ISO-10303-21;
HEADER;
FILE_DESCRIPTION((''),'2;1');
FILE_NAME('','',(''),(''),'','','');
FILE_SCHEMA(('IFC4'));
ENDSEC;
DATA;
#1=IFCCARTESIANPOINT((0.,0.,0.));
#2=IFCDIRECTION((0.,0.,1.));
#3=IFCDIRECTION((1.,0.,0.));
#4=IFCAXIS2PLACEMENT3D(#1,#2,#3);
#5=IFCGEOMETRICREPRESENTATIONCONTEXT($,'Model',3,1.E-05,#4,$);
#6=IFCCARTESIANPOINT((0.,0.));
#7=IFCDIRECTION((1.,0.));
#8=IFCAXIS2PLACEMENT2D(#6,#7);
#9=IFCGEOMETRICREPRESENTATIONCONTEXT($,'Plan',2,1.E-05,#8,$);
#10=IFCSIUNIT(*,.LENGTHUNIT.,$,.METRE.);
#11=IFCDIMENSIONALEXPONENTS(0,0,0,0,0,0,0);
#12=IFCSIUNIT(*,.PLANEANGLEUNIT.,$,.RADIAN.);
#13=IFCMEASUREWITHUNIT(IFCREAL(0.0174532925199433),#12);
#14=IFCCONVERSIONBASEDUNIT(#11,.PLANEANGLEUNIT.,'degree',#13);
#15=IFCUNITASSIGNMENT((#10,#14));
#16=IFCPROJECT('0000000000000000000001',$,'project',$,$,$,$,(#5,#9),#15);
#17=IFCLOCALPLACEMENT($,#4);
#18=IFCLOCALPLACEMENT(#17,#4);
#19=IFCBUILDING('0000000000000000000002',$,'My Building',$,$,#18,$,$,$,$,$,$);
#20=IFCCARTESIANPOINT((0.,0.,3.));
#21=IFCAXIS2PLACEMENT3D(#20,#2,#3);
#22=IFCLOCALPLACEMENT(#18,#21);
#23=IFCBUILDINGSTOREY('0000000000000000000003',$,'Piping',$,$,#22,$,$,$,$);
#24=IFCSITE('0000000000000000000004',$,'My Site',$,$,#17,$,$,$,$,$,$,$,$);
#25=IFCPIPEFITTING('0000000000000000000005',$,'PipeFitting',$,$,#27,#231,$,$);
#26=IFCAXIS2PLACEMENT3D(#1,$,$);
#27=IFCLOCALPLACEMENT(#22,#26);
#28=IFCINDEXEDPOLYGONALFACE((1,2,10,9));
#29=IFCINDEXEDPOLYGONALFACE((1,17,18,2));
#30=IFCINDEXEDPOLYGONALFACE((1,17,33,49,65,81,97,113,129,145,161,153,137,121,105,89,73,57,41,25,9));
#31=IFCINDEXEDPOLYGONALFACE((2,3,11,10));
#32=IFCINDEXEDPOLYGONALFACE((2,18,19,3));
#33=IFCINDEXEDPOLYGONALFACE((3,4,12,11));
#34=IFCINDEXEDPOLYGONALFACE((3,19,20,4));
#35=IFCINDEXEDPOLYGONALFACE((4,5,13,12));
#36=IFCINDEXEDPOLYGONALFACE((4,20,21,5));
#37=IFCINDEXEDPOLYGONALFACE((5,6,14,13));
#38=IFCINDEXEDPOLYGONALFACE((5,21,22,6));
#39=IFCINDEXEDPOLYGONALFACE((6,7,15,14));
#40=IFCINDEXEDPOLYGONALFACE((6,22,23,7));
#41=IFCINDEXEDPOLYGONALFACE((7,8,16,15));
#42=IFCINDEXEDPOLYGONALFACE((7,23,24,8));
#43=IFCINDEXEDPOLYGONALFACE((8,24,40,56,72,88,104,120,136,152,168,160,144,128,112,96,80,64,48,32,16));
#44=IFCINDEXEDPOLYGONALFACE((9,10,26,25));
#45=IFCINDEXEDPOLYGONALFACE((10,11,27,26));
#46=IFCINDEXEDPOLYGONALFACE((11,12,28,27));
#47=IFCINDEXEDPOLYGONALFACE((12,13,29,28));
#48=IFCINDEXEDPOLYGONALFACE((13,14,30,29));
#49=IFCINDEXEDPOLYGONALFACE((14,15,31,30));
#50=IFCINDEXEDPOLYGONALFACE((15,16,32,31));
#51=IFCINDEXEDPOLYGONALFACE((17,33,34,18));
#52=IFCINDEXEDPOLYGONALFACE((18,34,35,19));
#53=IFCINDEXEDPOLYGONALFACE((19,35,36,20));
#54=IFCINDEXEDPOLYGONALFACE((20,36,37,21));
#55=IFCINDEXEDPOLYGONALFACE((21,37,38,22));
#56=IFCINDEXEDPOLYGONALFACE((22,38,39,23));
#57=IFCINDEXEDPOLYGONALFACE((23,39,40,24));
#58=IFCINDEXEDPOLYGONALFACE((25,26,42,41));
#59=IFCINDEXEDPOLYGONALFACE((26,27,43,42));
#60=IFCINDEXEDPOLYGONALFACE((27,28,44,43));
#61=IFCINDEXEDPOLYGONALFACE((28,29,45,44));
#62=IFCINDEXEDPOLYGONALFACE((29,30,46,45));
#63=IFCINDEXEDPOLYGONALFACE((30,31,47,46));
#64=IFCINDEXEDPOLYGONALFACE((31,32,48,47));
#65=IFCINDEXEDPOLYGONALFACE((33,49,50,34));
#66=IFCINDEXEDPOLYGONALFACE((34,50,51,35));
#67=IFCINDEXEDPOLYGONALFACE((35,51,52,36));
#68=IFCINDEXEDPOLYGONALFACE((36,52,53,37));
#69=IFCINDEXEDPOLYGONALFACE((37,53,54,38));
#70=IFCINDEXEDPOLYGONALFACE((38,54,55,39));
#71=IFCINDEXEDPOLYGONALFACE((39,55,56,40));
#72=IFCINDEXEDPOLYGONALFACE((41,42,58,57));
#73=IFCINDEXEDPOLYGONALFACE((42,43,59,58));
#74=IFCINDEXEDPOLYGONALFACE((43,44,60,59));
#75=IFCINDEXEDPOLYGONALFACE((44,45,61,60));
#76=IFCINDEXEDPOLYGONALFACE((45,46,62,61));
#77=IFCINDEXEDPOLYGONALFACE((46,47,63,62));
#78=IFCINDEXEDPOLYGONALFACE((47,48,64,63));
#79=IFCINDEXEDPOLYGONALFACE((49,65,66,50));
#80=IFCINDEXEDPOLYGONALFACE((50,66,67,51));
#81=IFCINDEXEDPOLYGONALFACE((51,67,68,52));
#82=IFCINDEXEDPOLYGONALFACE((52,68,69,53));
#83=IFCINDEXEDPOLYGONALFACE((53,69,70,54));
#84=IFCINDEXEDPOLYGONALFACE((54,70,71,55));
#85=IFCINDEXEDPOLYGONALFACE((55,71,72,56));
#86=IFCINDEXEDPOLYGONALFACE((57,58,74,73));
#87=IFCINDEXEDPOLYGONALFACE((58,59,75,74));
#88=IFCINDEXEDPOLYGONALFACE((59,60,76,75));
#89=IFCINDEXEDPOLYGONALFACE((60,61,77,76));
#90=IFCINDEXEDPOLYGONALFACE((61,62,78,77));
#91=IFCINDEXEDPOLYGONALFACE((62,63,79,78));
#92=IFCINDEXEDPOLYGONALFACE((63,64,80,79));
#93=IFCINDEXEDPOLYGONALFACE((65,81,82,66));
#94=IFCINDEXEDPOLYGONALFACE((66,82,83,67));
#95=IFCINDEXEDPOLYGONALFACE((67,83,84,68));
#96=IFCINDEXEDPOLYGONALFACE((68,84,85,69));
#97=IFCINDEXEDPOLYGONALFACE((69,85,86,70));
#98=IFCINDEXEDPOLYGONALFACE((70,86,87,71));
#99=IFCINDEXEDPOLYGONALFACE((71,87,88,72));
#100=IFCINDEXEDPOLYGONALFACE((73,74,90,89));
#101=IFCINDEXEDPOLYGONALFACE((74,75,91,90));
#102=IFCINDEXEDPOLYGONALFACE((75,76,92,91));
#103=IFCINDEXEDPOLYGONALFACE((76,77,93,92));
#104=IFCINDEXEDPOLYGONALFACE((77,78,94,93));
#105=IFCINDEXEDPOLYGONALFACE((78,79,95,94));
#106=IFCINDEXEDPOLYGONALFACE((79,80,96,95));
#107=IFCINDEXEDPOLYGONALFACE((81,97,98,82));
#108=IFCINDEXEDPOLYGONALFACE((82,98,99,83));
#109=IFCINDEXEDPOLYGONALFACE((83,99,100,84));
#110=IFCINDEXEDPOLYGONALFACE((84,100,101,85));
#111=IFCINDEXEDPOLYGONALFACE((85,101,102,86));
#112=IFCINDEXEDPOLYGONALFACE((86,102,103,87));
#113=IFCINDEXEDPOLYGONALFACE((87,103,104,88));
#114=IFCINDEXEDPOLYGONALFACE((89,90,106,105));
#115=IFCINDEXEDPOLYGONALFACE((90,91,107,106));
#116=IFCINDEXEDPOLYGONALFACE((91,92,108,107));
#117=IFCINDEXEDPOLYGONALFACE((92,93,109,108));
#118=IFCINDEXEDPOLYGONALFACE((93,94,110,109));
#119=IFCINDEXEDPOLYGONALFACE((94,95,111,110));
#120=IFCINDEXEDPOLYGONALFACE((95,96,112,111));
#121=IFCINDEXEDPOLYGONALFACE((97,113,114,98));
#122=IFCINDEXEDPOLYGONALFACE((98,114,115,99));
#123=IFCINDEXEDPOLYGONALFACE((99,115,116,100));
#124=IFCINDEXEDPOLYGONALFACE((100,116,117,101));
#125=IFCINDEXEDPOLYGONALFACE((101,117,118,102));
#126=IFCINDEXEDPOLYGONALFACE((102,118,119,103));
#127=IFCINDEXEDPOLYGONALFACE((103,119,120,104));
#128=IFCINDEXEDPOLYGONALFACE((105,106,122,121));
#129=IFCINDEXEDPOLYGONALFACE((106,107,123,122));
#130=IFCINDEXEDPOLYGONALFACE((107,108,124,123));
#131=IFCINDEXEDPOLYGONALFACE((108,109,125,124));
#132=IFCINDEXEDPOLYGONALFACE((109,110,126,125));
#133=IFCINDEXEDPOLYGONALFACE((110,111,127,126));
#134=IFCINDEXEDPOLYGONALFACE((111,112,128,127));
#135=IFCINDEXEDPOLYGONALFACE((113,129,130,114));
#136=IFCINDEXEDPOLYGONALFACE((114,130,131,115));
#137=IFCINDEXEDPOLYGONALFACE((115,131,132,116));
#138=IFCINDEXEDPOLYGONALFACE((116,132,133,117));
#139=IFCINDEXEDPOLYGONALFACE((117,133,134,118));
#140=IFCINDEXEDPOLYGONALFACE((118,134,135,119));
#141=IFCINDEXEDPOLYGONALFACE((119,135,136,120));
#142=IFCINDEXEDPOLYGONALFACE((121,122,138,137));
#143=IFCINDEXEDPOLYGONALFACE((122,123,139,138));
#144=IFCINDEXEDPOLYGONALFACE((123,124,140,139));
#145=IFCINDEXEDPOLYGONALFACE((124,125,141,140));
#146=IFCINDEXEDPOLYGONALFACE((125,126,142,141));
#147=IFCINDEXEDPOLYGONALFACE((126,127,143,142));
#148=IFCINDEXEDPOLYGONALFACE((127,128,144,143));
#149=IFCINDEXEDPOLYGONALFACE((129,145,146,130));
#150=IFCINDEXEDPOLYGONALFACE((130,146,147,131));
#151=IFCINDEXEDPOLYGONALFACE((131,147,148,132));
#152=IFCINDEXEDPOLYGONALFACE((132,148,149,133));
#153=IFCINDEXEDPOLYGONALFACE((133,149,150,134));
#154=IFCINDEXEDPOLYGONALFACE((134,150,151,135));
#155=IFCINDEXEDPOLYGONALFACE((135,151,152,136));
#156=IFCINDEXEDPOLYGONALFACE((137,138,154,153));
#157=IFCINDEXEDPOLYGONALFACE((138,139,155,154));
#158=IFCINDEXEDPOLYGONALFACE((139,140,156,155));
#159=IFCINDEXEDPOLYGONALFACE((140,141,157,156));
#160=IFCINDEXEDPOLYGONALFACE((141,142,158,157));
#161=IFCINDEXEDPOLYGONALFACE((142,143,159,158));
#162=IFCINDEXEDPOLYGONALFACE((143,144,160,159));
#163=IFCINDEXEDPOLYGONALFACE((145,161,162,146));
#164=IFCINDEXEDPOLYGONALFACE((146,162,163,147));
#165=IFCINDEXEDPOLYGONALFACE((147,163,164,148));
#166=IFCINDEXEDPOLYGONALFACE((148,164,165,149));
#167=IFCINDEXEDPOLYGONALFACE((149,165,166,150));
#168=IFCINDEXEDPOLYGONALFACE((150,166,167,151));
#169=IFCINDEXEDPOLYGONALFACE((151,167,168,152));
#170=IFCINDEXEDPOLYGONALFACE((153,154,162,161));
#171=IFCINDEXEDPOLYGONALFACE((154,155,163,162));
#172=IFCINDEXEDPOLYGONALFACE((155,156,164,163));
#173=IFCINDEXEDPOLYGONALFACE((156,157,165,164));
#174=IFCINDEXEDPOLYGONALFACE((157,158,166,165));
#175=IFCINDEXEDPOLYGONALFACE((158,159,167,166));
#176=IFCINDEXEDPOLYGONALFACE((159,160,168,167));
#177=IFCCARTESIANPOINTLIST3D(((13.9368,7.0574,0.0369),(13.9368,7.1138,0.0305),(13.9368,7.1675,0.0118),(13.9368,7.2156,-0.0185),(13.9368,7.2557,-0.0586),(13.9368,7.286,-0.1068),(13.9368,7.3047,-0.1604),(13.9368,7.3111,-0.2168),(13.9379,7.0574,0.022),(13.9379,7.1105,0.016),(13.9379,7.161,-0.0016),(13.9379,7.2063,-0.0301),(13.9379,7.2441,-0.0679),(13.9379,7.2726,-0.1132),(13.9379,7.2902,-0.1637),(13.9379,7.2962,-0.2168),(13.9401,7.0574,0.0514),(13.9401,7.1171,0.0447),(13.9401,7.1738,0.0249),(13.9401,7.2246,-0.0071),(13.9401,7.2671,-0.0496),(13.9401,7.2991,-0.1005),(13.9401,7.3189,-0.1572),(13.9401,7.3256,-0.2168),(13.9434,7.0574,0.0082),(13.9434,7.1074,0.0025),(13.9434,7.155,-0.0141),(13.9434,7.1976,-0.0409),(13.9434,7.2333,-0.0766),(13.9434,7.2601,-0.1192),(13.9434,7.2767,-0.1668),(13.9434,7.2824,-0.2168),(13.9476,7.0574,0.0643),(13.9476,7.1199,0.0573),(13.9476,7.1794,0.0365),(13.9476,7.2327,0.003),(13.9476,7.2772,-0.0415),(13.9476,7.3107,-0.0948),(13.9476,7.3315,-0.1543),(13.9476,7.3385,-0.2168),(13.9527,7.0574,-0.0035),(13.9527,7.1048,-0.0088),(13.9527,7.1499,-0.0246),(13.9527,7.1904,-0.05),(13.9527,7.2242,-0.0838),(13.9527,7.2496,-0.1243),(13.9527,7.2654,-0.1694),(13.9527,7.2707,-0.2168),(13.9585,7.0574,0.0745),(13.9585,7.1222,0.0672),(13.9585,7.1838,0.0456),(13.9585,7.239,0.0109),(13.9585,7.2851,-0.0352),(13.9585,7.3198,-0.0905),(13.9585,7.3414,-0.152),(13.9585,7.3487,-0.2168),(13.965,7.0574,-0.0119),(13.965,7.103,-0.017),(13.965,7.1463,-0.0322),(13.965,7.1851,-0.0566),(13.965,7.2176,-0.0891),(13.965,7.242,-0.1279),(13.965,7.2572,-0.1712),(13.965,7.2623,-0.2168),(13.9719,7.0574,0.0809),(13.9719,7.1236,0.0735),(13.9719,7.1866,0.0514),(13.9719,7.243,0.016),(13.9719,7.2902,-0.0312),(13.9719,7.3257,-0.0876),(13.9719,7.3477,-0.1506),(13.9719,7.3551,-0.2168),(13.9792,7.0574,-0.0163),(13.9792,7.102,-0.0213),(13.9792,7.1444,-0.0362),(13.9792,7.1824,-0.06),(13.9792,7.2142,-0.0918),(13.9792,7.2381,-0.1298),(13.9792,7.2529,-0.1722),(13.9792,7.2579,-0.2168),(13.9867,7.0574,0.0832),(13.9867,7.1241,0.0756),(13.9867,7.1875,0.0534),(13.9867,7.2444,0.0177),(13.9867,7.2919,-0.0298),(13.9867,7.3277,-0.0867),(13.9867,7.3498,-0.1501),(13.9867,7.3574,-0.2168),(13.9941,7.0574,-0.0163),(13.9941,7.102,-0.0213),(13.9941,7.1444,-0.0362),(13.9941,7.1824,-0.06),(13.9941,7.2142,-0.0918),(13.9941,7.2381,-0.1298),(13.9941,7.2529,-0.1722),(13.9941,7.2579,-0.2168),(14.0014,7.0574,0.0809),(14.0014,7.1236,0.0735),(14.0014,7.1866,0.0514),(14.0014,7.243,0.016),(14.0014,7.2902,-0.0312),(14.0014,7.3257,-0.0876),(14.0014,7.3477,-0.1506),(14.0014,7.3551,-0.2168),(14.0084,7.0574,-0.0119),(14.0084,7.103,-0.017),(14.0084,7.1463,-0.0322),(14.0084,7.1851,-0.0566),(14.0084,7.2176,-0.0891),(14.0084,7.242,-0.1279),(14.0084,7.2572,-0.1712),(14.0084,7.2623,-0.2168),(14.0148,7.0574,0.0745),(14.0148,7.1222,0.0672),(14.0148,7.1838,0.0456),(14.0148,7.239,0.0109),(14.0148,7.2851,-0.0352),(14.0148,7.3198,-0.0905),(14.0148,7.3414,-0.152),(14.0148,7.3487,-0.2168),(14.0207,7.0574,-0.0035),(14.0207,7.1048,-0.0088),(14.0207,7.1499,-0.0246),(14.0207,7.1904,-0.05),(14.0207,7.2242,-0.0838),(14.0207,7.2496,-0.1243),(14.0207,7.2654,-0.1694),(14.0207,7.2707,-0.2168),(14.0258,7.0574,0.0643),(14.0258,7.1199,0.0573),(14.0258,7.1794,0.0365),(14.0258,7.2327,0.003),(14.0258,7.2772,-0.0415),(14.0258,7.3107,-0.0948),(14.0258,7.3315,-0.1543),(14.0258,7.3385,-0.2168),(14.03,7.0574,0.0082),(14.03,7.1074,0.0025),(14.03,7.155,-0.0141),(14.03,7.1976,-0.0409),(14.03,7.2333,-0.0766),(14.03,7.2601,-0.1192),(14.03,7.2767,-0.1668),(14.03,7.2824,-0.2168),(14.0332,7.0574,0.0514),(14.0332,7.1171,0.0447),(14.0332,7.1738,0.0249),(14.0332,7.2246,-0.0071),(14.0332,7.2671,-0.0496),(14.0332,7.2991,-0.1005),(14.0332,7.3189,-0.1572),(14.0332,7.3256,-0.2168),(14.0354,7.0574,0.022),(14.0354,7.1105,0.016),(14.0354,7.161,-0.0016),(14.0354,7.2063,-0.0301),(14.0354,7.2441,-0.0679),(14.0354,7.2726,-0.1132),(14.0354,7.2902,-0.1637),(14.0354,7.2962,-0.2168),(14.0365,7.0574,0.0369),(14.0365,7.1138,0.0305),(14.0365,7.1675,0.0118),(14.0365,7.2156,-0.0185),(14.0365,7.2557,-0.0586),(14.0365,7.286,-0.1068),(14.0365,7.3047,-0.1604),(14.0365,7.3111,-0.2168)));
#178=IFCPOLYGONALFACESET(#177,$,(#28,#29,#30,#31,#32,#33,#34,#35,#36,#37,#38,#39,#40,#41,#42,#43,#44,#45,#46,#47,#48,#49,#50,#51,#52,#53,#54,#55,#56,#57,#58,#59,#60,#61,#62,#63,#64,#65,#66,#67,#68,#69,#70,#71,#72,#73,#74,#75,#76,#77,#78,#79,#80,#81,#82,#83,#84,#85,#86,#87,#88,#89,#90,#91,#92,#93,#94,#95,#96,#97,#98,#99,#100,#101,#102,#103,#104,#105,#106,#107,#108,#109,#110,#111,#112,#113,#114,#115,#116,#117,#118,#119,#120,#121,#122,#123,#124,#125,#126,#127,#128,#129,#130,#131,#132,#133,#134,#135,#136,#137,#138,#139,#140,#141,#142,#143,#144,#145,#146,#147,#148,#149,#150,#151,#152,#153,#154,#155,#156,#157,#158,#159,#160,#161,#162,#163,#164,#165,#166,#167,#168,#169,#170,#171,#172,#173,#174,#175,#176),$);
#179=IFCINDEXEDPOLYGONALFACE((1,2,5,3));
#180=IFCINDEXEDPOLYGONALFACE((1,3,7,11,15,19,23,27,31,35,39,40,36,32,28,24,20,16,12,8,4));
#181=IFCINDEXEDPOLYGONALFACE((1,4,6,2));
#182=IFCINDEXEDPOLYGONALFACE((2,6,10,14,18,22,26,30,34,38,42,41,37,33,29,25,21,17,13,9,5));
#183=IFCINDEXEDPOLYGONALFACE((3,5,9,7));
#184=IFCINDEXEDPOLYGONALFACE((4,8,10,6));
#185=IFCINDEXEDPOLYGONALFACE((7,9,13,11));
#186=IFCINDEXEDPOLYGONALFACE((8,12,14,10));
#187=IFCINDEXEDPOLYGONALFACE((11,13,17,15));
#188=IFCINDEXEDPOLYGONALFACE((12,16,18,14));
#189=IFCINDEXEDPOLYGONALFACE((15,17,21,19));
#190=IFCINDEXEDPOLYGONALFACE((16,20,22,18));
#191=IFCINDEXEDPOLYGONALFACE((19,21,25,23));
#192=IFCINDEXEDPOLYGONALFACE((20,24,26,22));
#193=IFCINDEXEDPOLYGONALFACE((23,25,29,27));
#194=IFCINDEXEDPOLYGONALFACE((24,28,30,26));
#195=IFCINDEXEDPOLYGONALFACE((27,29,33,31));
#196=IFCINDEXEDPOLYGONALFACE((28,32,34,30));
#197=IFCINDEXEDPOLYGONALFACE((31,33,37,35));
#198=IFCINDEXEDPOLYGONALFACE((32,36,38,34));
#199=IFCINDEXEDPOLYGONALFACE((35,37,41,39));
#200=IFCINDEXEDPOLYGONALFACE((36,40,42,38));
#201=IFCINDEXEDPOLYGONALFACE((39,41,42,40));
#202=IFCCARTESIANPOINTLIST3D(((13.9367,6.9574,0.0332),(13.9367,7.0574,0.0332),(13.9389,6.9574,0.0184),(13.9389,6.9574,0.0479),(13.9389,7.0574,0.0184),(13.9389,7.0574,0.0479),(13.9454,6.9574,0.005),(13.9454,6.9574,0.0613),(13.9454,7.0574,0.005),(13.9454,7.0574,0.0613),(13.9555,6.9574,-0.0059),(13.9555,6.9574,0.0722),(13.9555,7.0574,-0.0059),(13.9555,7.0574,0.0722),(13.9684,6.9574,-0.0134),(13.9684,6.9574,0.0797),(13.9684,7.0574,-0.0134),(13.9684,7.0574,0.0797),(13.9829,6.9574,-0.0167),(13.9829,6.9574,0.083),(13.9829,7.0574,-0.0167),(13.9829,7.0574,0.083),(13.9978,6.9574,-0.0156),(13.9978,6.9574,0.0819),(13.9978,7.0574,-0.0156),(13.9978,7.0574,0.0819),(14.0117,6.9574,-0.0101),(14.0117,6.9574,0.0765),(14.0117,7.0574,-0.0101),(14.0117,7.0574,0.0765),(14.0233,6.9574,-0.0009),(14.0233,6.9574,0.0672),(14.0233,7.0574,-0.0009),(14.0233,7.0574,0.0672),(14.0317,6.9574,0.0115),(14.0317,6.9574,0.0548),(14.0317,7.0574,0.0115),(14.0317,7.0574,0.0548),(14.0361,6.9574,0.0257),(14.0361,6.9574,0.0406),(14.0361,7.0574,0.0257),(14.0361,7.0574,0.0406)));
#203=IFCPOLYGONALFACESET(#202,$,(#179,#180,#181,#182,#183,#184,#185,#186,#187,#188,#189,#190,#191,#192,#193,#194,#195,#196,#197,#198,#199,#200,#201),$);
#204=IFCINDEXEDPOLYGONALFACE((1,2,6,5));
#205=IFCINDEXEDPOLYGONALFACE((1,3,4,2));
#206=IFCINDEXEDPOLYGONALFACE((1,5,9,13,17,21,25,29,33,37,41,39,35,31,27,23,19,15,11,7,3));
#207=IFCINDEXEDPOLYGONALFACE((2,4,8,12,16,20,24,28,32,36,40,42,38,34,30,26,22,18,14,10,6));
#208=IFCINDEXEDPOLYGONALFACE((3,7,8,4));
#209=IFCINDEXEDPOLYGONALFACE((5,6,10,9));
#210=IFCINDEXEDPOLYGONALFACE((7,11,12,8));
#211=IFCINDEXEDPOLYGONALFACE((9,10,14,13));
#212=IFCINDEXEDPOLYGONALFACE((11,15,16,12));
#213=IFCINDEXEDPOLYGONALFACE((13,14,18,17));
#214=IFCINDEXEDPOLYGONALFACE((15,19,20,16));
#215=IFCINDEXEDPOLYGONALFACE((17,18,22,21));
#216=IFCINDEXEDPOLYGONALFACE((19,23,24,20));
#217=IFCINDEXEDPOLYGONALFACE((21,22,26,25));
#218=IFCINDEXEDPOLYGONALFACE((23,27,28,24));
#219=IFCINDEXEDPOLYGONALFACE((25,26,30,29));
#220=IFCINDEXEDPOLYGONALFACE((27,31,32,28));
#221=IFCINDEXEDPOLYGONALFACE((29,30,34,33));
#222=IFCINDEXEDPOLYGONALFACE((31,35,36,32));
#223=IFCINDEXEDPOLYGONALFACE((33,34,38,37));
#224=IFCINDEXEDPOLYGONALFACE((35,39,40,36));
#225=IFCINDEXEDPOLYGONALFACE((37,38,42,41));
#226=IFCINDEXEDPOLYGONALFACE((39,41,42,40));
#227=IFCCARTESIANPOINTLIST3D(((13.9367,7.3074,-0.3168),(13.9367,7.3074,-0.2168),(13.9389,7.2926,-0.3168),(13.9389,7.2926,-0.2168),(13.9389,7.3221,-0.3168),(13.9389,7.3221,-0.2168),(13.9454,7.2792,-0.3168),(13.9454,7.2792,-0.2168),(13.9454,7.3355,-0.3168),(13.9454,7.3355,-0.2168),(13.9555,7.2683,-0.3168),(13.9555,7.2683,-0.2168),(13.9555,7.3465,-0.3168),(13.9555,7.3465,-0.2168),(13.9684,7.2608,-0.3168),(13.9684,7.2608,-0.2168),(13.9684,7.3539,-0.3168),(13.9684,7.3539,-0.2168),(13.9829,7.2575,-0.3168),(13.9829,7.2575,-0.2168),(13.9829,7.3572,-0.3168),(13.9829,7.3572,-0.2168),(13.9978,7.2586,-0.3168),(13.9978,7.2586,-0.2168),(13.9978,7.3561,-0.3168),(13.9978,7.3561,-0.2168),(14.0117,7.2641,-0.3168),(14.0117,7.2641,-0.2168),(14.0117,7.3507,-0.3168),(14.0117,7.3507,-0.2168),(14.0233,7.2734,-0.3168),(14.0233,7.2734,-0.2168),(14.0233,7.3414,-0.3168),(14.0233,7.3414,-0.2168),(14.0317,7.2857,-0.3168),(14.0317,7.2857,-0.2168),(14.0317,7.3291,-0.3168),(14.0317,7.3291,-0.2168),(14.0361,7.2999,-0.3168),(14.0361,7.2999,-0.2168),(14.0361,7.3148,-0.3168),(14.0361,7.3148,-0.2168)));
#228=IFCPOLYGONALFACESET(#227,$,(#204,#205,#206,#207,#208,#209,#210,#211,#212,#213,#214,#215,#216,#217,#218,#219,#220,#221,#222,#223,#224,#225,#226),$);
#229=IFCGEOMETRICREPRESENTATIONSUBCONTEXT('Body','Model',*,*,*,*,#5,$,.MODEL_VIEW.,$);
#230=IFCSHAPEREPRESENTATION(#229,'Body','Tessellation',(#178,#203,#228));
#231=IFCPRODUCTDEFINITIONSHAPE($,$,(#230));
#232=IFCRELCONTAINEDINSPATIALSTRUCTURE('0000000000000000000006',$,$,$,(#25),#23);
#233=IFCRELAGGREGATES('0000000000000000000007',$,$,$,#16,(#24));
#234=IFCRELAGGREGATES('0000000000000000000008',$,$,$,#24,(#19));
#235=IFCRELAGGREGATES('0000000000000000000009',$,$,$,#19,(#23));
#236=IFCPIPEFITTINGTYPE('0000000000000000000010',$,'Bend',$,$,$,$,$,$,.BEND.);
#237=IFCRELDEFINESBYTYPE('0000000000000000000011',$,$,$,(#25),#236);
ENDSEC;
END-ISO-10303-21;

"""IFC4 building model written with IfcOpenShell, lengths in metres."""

from ifc_helpers import new_model, entity, si_unit, converted_unit, frame, origin_with_axes, origin_2d_with_axis, place, context, subcontext, project, spatial, circle, extrude, source, transform, mapped, type_object, type_shapes, element, save


model = new_model("IFC4")

# Units and contexts
model_context = context("Model", 3, precision=1e-05, world=origin_with_axes())
plan_context = context("Plan", 2, precision=1e-05, world=origin_2d_with_axis())
body_context = subcontext(model_context, "Body", "Model", "MODEL_VIEW")
ifc_project = project(units=[si_unit("LENGTHUNIT", "METRE"), converted_unit("PLANEANGLEUNIT", "degree", entity("IfcReal", 0.0174532925199433), si_unit("PLANEANGLEUNIT", "RADIAN"), dimensions=[0, 0, 0, 0, 0, 0, 0])], contexts=[model_context, plan_context])

# Site, building, storey
site_placement = place(None, origin_with_axes())
site = spatial("IfcSite", under=ifc_project, at=site_placement, Name="My Site")
building_placement = place(site_placement, origin_with_axes())
building = spatial("IfcBuilding", under=site, at=building_placement, Name="My Building")
storey_placement = place(building_placement, frame((0.0, 0.0, 3.0), z_axis=(0.0, 0.0, 1.0), x_axis=(1.0, 0.0, 0.0)))
storey = spatial("IfcBuildingStorey", under=building, at=storey_placement, Name="Piping")

# Pipe fitting
pipe_fitting_type = type_object("IfcPipeFittingType", Name="Bend", PredefinedType="BEND")
shared_shape = source(origin_with_axes(), body_context, "Body", "SolidModel", [
    entity("IfcSweptDiskSolid", entity("IfcIndexedPolyCurve", entity("IfcCartesianPointList3D", [[0.0, 0.0, -0.1], [0.0, 0.0732, -0.2768], [0.0, 0.25, -0.35]]), [entity("IfcArcIndex", [1, 2, 3])]), 0.05),
    extrude(circle(Radius=0.05), origin_with_axes(), (0.0, 0.0, -1.0), 0.1),
    extrude(circle(Radius=0.05), frame((0.0, 0.25, -0.35), z_axis=(0.0, 1.0, 0.0), x_axis=(1.0, 0.0, 0.0)), (0.0, 0.0, 1.0), 0.1),
])
type_shapes(pipe_fitting_type, [shared_shape])
for number, where, z_axis, x_axis, name in (
    (1, (13.9867, 6.9574, 0.0332), (0.0, -1.0, 0.0), (-1.0, 0.0, 0.0), "PipeFitting"),
):
    element("IfcPipeFitting", number, at=place(storey_placement, frame(where, z_axis=z_axis, x_axis=x_axis)), inside=storey, type_object=pipe_fitting_type, Name=name, context=body_context, shape_type="MappedRepresentation", body=[
        mapped(shared_shape, transform((0.0, 0.0, 0.0), x_axis=(1.0, 0.0, 0.0), y_axis=(0.0, 1.0, 0.0), z_axis=(0.0, 0.0, 1.0), scale=1.0)),
    ])

save(model, "model.ifc")
